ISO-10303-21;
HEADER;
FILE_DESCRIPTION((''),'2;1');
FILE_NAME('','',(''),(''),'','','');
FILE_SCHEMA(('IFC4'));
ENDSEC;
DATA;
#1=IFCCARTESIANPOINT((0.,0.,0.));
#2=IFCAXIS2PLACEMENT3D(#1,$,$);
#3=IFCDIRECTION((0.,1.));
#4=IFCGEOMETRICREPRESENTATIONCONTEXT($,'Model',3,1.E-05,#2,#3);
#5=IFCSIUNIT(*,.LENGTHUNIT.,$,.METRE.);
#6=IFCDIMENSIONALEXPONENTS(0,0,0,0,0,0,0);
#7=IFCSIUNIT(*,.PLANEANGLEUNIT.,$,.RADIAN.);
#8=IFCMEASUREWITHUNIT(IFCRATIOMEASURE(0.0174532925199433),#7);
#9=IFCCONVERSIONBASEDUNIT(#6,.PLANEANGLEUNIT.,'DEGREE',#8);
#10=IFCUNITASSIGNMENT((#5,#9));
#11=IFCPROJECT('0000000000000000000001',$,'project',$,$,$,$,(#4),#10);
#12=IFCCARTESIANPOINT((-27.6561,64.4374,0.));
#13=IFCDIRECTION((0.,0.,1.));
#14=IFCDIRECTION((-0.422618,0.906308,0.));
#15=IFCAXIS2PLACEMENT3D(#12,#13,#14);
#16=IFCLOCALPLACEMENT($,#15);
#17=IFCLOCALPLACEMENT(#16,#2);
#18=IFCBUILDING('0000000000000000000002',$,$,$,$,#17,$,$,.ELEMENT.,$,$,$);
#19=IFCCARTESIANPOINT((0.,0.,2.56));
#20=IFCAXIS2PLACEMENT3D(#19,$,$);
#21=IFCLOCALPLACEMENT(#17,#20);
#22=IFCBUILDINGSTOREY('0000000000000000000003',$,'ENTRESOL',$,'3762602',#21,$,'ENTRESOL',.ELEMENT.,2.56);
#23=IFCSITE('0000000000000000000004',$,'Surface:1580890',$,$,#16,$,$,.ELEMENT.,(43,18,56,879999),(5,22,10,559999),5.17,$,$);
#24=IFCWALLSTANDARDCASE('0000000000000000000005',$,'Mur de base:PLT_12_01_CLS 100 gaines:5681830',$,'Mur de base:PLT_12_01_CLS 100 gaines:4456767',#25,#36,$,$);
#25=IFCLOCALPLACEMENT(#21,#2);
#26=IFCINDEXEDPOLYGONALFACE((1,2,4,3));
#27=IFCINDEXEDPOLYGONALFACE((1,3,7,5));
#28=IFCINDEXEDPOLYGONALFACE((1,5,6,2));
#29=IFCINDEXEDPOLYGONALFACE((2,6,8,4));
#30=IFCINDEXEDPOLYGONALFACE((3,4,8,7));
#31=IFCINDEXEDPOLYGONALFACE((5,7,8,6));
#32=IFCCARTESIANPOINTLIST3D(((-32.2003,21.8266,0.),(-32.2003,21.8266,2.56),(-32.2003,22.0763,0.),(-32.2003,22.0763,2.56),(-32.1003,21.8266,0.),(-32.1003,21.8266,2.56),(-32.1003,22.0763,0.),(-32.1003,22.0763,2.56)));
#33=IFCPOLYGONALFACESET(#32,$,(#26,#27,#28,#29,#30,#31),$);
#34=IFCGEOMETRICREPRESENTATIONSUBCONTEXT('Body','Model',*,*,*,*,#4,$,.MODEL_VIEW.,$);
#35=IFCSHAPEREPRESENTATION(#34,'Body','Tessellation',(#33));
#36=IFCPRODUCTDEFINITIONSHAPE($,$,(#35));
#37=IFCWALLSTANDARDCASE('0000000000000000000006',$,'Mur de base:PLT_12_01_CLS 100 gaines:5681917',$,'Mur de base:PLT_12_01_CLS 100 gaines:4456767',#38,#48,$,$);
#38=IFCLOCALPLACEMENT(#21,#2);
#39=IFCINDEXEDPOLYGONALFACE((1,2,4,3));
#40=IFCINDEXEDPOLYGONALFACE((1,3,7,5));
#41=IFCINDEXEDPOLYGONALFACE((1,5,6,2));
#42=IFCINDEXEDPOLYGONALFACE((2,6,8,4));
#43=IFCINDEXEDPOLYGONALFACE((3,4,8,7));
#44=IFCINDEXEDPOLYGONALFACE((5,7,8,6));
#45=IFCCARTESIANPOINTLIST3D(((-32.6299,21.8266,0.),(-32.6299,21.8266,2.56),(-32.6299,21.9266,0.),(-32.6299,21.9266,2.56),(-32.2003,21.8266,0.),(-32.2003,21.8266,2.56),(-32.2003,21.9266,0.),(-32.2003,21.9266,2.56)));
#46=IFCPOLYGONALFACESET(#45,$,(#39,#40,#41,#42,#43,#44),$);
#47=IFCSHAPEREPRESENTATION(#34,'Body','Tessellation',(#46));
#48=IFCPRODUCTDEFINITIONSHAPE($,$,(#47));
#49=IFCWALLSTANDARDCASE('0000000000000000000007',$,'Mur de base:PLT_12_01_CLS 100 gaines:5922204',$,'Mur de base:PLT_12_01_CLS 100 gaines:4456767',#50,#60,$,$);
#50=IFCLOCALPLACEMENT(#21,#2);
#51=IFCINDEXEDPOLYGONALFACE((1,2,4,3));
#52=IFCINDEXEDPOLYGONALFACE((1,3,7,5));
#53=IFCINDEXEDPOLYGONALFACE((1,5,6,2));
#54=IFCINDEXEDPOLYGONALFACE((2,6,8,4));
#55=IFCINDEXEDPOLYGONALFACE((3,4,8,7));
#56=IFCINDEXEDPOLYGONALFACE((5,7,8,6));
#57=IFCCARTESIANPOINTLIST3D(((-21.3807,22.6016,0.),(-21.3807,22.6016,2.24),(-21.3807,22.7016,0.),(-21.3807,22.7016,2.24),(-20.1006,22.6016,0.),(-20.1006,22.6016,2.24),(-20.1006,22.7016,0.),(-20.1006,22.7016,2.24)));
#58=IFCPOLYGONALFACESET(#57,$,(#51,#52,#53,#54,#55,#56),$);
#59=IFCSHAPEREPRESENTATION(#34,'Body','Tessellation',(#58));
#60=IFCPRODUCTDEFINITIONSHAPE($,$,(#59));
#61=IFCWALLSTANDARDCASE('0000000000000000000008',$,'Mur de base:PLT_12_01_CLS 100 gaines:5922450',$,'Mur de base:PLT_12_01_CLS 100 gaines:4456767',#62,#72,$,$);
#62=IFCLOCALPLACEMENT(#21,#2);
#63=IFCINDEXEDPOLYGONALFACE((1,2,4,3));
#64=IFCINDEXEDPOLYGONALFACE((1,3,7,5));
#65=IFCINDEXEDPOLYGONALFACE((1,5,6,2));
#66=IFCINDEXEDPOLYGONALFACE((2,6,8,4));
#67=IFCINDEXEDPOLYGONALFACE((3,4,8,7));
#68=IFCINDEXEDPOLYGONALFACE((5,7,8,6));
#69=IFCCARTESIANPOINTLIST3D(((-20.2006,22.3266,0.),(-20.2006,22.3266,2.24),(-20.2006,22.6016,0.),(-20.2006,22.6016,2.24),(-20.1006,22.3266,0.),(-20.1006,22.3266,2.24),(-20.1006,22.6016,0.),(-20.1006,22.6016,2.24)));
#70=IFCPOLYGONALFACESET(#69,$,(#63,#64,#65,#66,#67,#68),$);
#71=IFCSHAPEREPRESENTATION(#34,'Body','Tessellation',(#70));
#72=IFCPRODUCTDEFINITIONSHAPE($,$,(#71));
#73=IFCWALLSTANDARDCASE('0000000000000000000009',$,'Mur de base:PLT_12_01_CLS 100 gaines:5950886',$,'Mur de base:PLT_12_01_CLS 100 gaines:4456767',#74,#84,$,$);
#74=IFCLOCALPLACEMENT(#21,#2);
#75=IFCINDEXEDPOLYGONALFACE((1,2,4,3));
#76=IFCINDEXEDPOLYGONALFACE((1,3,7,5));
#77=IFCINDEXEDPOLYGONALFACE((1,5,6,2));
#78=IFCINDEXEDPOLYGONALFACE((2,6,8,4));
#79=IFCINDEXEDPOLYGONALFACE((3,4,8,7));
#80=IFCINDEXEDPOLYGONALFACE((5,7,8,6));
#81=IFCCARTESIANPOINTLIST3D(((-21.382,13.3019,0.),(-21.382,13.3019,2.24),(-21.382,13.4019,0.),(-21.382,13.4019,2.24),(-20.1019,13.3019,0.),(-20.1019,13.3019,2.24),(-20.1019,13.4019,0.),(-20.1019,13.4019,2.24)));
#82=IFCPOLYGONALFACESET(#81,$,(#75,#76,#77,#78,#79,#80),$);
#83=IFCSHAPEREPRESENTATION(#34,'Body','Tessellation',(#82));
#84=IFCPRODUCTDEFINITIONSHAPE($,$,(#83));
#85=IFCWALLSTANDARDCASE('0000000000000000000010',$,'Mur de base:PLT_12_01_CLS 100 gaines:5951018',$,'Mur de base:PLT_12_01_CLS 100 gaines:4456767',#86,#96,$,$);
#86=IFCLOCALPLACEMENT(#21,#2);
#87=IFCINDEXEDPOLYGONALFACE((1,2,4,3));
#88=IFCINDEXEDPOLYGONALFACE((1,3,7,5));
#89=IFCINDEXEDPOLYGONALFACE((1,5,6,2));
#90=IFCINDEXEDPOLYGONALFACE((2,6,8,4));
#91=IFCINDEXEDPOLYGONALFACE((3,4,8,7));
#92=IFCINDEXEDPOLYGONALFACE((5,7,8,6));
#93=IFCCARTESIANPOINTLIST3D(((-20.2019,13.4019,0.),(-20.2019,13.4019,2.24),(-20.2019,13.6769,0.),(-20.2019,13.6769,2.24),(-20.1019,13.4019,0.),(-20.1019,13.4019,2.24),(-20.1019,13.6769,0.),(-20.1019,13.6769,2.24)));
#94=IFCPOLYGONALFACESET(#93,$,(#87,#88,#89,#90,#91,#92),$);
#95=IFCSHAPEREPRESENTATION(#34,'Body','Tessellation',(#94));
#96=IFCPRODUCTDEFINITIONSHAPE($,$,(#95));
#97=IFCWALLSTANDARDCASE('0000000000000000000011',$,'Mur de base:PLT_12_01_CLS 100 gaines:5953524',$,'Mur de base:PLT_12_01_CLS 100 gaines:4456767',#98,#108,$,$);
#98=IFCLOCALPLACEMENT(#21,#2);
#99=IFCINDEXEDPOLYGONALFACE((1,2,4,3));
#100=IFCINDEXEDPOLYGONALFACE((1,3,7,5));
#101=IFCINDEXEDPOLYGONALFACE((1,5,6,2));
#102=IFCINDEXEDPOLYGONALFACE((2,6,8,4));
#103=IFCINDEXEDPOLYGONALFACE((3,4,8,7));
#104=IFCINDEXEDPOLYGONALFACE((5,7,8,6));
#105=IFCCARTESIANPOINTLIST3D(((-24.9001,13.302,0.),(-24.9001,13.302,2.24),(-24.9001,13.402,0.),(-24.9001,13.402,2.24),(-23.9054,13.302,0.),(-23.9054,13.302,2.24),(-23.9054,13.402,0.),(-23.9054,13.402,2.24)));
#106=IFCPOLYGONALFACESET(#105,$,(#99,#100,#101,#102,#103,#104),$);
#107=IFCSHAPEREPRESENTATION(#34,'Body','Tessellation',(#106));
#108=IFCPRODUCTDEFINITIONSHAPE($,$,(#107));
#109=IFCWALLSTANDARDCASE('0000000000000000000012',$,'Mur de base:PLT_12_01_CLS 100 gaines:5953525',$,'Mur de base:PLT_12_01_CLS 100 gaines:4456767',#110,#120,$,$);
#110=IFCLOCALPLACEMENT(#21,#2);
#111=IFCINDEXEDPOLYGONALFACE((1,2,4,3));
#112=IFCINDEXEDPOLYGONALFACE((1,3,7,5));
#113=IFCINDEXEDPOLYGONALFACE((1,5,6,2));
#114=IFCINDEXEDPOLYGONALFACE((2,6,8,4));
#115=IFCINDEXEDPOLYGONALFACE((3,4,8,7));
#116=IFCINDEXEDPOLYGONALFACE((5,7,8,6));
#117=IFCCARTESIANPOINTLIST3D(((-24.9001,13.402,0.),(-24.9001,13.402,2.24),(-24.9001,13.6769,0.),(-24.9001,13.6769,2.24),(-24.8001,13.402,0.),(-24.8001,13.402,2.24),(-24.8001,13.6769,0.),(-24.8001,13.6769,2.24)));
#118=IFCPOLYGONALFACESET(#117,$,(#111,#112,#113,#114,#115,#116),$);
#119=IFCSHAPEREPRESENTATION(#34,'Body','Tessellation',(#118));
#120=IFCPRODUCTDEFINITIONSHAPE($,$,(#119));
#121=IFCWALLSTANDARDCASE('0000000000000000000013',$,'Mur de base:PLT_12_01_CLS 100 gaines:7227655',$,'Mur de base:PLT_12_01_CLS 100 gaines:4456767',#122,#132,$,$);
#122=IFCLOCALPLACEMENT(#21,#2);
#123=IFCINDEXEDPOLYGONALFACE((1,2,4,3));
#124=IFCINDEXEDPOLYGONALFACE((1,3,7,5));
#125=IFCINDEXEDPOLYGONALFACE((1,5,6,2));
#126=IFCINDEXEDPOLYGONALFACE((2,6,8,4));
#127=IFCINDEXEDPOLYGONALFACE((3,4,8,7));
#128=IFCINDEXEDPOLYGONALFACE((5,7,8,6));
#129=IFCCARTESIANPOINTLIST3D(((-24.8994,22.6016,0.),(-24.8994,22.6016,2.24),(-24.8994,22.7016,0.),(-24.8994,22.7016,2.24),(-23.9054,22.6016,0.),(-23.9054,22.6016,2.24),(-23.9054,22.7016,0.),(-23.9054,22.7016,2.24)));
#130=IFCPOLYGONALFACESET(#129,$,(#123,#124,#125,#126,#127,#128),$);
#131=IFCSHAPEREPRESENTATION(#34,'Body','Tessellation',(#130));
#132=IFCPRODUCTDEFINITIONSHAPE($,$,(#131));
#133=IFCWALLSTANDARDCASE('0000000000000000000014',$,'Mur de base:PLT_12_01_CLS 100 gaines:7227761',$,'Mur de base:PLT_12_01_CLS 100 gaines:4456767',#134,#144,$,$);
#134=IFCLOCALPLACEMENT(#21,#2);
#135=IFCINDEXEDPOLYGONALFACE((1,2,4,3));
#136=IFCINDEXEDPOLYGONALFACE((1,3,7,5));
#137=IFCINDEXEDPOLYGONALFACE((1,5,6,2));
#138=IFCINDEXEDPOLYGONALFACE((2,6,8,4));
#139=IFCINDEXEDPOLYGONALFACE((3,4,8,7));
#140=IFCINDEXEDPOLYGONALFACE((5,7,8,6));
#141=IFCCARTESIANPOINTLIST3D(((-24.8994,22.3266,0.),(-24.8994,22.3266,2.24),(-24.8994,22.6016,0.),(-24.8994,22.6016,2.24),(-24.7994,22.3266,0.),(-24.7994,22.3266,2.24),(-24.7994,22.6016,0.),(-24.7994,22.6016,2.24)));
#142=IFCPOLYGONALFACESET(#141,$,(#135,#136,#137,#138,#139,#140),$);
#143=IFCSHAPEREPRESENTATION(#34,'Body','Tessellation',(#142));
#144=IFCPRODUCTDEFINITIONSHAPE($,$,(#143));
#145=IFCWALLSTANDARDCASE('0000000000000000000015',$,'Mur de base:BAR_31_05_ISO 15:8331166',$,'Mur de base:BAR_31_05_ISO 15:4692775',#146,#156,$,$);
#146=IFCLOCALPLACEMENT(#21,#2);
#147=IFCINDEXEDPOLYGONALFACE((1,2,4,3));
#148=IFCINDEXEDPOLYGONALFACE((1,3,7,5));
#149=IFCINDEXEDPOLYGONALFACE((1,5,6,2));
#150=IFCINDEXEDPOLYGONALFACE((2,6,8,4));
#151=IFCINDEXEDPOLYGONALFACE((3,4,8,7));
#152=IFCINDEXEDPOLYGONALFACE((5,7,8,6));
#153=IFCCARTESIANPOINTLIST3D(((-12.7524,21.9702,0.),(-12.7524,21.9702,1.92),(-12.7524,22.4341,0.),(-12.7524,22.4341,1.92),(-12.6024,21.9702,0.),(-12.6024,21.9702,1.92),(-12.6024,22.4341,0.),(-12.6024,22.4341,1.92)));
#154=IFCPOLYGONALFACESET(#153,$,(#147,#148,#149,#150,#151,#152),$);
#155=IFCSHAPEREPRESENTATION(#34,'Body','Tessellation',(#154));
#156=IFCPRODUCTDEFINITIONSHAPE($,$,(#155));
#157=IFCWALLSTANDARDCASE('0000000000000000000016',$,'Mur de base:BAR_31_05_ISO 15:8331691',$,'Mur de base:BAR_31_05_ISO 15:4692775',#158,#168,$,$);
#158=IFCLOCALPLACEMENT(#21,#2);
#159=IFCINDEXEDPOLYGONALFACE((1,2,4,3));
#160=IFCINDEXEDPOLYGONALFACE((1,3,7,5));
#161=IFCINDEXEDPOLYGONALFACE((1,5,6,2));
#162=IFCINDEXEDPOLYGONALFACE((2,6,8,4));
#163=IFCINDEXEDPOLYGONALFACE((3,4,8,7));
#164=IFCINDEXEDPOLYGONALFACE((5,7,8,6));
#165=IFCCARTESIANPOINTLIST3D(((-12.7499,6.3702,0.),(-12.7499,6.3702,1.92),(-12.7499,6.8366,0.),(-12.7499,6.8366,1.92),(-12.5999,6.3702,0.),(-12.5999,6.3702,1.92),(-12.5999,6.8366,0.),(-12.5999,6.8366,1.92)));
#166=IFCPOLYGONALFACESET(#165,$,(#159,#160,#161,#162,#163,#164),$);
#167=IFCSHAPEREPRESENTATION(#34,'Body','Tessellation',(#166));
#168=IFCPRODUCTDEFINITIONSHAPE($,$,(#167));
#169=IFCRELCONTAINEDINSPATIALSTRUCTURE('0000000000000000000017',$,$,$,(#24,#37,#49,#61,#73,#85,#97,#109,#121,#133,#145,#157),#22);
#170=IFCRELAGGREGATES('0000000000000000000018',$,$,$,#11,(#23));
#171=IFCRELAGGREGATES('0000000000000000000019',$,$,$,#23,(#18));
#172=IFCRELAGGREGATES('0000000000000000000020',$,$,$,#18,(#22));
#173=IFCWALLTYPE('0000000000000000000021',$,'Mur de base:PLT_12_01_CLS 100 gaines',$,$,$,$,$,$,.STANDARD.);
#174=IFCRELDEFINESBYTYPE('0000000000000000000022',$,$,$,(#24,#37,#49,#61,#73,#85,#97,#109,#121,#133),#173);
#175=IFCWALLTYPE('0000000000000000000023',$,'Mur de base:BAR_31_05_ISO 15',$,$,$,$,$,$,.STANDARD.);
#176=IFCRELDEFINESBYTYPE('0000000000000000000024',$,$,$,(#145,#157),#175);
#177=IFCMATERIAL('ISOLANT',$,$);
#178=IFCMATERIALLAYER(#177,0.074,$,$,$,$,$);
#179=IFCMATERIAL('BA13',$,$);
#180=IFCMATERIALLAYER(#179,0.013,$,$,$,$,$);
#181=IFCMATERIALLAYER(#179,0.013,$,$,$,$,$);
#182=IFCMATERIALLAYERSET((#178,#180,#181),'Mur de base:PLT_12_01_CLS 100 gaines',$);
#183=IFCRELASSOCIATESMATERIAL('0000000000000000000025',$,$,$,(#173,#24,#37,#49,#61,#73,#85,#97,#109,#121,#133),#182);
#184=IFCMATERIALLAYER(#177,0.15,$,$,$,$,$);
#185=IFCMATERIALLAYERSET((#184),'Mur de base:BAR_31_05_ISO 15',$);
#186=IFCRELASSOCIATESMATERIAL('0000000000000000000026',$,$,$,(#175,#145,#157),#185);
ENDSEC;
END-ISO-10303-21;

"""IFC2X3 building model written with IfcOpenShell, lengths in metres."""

from ifc_helpers import new_model, entity, si_unit, converted_unit, direction, frame, frame_2d, origin, place, context, subcontext, project, spatial, rectangle, extrude, clip, halfspace, material, layer, layer_set, layer_usage, type_object, element, save


model = new_model("IFC2X3")

# Units and contexts
model_context = context("Model", 3, precision=1e-05, world=origin(), true_north=direction((0.0, 1.0)))
body_context = subcontext(model_context, "Body", "Model", "MODEL_VIEW")
ifc_project = project(units=[si_unit("LENGTHUNIT", "METRE"), converted_unit("PLANEANGLEUNIT", "DEGREE", entity("IfcRatioMeasure", 0.0174532925199433), si_unit("PLANEANGLEUNIT", "RADIAN"), dimensions=[0, 0, 0, 0, 0, 0, 0])], contexts=[model_context])

# Site, building, storey
site_placement = place(None, frame((-27.6561, 64.4374, 0.0), z_axis=(0.0, 0.0, 1.0), x_axis=(-0.422618, 0.906308, 0.0)))
site = spatial("IfcSite", under=ifc_project, at=site_placement, Name="Surface:1580890", CompositionType="ELEMENT", RefLatitude=(43, 18, 56, 879999), RefLongitude=(5, 22, 10, 559999), RefElevation=5.17)
building_placement = place(site_placement, origin())
building = spatial("IfcBuilding", under=site, at=building_placement, CompositionType="ELEMENT")
storey_placement = place(building_placement, frame((0.0, 0.0, 2.56)))
storey = spatial("IfcBuildingStorey", under=building, at=storey_placement, Name="ENTRESOL", ObjectType="3762602", LongName="ENTRESOL", CompositionType="ELEMENT", Elevation=2.56)

# Shared definitions
ifc_material_1 = material(Name="BA13")
ifc_material_2 = material(Name="ISOLANT")

# Walls
ifc_layer_1 = layer(ifc_material_2, 0.074)
ifc_layer_2 = layer(ifc_material_1, 0.013)
ifc_layer_3 = layer(ifc_material_1, 0.013)
ifc_layer_set_1 = layer_set([ifc_layer_1, ifc_layer_2, ifc_layer_3], Name="Mur de base:PLT_12_01_CLS 100 gaines")
wall_type_1 = type_object("IfcWallType", Name="Mur de base:PLT_12_01_CLS 100 gaines", PredefinedType="STANDARD", material=ifc_layer_set_1)
ifc_layer_usage_1 = layer_usage(ifc_layer_set_1, "AXIS2", "POSITIVE", -0.05)
wall_1_placement = place(storey_placement, frame((-32.1503, 22.0763, 0.0), z_axis=(0.0, 0.0, 1.0), x_axis=(0.0, -1.0, 0.0)))
element("IfcWallStandardCase", 1, at=wall_1_placement, inside=storey, type_object=wall_type_1, material=ifc_layer_usage_1, Name="Mur de base:PLT_12_01_CLS 100 gaines:5681830", ObjectType="Mur de base:PLT_12_01_CLS 100 gaines:4456767", context=body_context, shape_type="Clipping", body=[
    clip(extrude(rectangle(XDim=0.2497, YDim=0.1, at=frame_2d((0.1249, 0.0), x_axis=(-1.0, 0.0))), origin(), (0.0, 0.0, 1.0), 2.56), halfspace(frame((0.0, 0.0, -2.56)), True)),
])
ifc_layer_usage_2 = layer_usage(ifc_layer_set_1, "AXIS2", "POSITIVE", -0.05)
wall_2_placement = place(storey_placement, frame((-32.2003, 21.8766, 0.0), z_axis=(0.0, 0.0, 1.0), x_axis=(-1.0, 0.0, 0.0)))
element("IfcWallStandardCase", 2, at=wall_2_placement, inside=storey, type_object=wall_type_1, material=ifc_layer_usage_2, Name="Mur de base:PLT_12_01_CLS 100 gaines:5681917", ObjectType="Mur de base:PLT_12_01_CLS 100 gaines:4456767", context=body_context, shape_type="Clipping", body=[
    clip(extrude(rectangle(XDim=0.4295, YDim=0.1, at=frame_2d((0.2148, 0.0), x_axis=(-1.0, 0.0))), origin(), (0.0, 0.0, 1.0), 2.56), halfspace(frame((0.0, 0.0, -2.56)), True)),
])
ifc_layer_usage_3 = layer_usage(ifc_layer_set_1, "AXIS2", "NEGATIVE", 0.05)
wall_3_placement = place(storey_placement, frame((-20.1006, 22.6516, 0.0), z_axis=(0.0, 0.0, 1.0), x_axis=(-1.0, 0.0, 0.0)))
element("IfcWallStandardCase", 3, at=wall_3_placement, inside=storey, type_object=wall_type_1, material=ifc_layer_usage_3, Name="Mur de base:PLT_12_01_CLS 100 gaines:5922204", ObjectType="Mur de base:PLT_12_01_CLS 100 gaines:4456767", context=body_context, shape_type="Clipping", body=[
    clip(extrude(rectangle(XDim=1.2801, YDim=0.1, at=frame_2d((0.64, 0.0), x_axis=(-1.0, 0.0))), origin(), (0.0, 0.0, 1.0), 2.24), halfspace(frame((0.0, 0.0, -2.56)), True)),
])
ifc_layer_usage_4 = layer_usage(ifc_layer_set_1, "AXIS2", "NEGATIVE", 0.05)
wall_4_placement = place(storey_placement, frame((-20.1506, 22.3266, 0.0), z_axis=(0.0, 0.0, 1.0), x_axis=(0.0, 1.0, 0.0)))
element("IfcWallStandardCase", 4, at=wall_4_placement, inside=storey, type_object=wall_type_1, material=ifc_layer_usage_4, Name="Mur de base:PLT_12_01_CLS 100 gaines:5922450", ObjectType="Mur de base:PLT_12_01_CLS 100 gaines:4456767", context=body_context, shape_type="Clipping", body=[
    clip(extrude(rectangle(XDim=0.275, YDim=0.1, at=frame_2d((0.1375, 0.0), x_axis=(-1.0, 0.0))), origin(), (0.0, 0.0, 1.0), 2.24), halfspace(frame((0.0, 0.0, -2.56)), True)),
])
ifc_layer_usage_5 = layer_usage(ifc_layer_set_1, "AXIS2", "POSITIVE", -0.05)
wall_5_placement = place(storey_placement, frame((-20.1019, 13.3519, 0.0), z_axis=(0.0, 0.0, 1.0), x_axis=(-1.0, 0.0, 0.0)))
element("IfcWallStandardCase", 5, at=wall_5_placement, inside=storey, type_object=wall_type_1, material=ifc_layer_usage_5, Name="Mur de base:PLT_12_01_CLS 100 gaines:5950886", ObjectType="Mur de base:PLT_12_01_CLS 100 gaines:4456767", context=body_context, shape_type="Clipping", body=[
    clip(extrude(rectangle(XDim=1.2801, YDim=0.1, at=frame_2d((0.64, 0.0), x_axis=(-1.0, 0.0))), origin(), (0.0, 0.0, 1.0), 2.24), halfspace(frame((0.0, 0.0, -2.56)), True)),
])
ifc_layer_usage_6 = layer_usage(ifc_layer_set_1, "AXIS2", "POSITIVE", -0.05)
wall_6_placement = place(storey_placement, frame((-20.1519, 13.6769, 0.0), z_axis=(0.0, 0.0, 1.0), x_axis=(0.0, -1.0, 0.0)))
element("IfcWallStandardCase", 6, at=wall_6_placement, inside=storey, type_object=wall_type_1, material=ifc_layer_usage_6, Name="Mur de base:PLT_12_01_CLS 100 gaines:5951018", ObjectType="Mur de base:PLT_12_01_CLS 100 gaines:4456767", context=body_context, shape_type="Clipping", body=[
    clip(extrude(rectangle(XDim=0.275, YDim=0.1, at=frame_2d((0.1375, 0.0), x_axis=(-1.0, 0.0))), origin(), (0.0, 0.0, 1.0), 2.24), halfspace(frame((0.0, 0.0, -2.56)), True)),
])
ifc_layer_usage_7 = layer_usage(ifc_layer_set_1, "AXIS2", "NEGATIVE", 0.05)
wall_7_placement = place(storey_placement, frame((-24.9001, 13.352, 0.0)))
element("IfcWallStandardCase", 7, at=wall_7_placement, inside=storey, type_object=wall_type_1, material=ifc_layer_usage_7, Name="Mur de base:PLT_12_01_CLS 100 gaines:5953524", ObjectType="Mur de base:PLT_12_01_CLS 100 gaines:4456767", context=body_context, shape_type="Clipping", body=[
    clip(extrude(rectangle(XDim=0.9947, YDim=0.1, at=frame_2d((0.4973, 0.0), x_axis=(-1.0, 0.0))), origin(), (0.0, 0.0, 1.0), 2.24), halfspace(frame((0.0, 0.0, -2.56)), True)),
])
ifc_layer_usage_8 = layer_usage(ifc_layer_set_1, "AXIS2", "NEGATIVE", 0.05)
wall_8_placement = place(storey_placement, frame((-24.8501, 13.6769, 0.0), z_axis=(0.0, 0.0, 1.0), x_axis=(0.0, -1.0, 0.0)))
element("IfcWallStandardCase", 8, at=wall_8_placement, inside=storey, type_object=wall_type_1, material=ifc_layer_usage_8, Name="Mur de base:PLT_12_01_CLS 100 gaines:5953525", ObjectType="Mur de base:PLT_12_01_CLS 100 gaines:4456767", context=body_context, shape_type="Clipping", body=[
    clip(extrude(rectangle(XDim=0.2749, YDim=0.1, at=frame_2d((0.1374, 0.0), x_axis=(-1.0, 0.0))), origin(), (0.0, 0.0, 1.0), 2.24), halfspace(frame((0.0, 0.0, -2.56)), True)),
])
ifc_layer_usage_9 = layer_usage(ifc_layer_set_1, "AXIS2", "POSITIVE", -0.05)
wall_9_placement = place(storey_placement, frame((-24.8994, 22.6516, 0.0)))
element("IfcWallStandardCase", 9, at=wall_9_placement, inside=storey, type_object=wall_type_1, material=ifc_layer_usage_9, Name="Mur de base:PLT_12_01_CLS 100 gaines:7227655", ObjectType="Mur de base:PLT_12_01_CLS 100 gaines:4456767", context=body_context, shape_type="Clipping", body=[
    clip(extrude(rectangle(XDim=0.994, YDim=0.1, at=frame_2d((0.497, 0.0), x_axis=(-1.0, 0.0))), origin(), (0.0, 0.0, 1.0), 2.24), halfspace(frame((0.0, 0.0, -2.56)), True)),
])
ifc_layer_usage_10 = layer_usage(ifc_layer_set_1, "AXIS2", "POSITIVE", -0.05)
wall_10_placement = place(storey_placement, frame((-24.8494, 22.3266, 0.0), z_axis=(0.0, 0.0, 1.0), x_axis=(0.0, 1.0, 0.0)))
element("IfcWallStandardCase", 10, at=wall_10_placement, inside=storey, type_object=wall_type_1, material=ifc_layer_usage_10, Name="Mur de base:PLT_12_01_CLS 100 gaines:7227761", ObjectType="Mur de base:PLT_12_01_CLS 100 gaines:4456767", context=body_context, shape_type="Clipping", body=[
    clip(extrude(rectangle(XDim=0.275, YDim=0.1, at=frame_2d((0.1375, 0.0), x_axis=(-1.0, 0.0))), origin(), (0.0, 0.0, 1.0), 2.24), halfspace(frame((0.0, 0.0, -2.56)), True)),
])
ifc_layer_4 = layer(ifc_material_2, 0.15)
ifc_layer_set_2 = layer_set([ifc_layer_4], Name="Mur de base:BAR_31_05_ISO 15")
ifc_layer_usage_11 = layer_usage(ifc_layer_set_2, "AXIS2", "NEGATIVE", 0.075)
wall_type_2 = type_object("IfcWallType", Name="Mur de base:BAR_31_05_ISO 15", PredefinedType="STANDARD", material=ifc_layer_set_2)
wall_11_placement = place(storey_placement, frame((-12.6774, 22.4341, 0.0), z_axis=(0.0, 0.0, 1.0), x_axis=(0.0, -1.0, 0.0)))
element("IfcWallStandardCase", 11, at=wall_11_placement, inside=storey, type_object=wall_type_2, material=ifc_layer_usage_11, Name="Mur de base:BAR_31_05_ISO 15:8331166", ObjectType="Mur de base:BAR_31_05_ISO 15:4692775", context=body_context, shape_type="Clipping", body=[
    clip(extrude(rectangle(XDim=0.464, YDim=0.15, at=frame_2d((0.232, 0.0), x_axis=(-1.0, 0.0))), origin(), (0.0, 0.0, 1.0), 1.92), halfspace(frame((0.0, 0.0, -2.56)), True)),
])
ifc_layer_usage_12 = layer_usage(ifc_layer_set_2, "AXIS2", "NEGATIVE", 0.075)
wall_12_placement = place(storey_placement, frame((-12.6749, 6.8366, 0.0), z_axis=(0.0, 0.0, 1.0), x_axis=(0.0, -1.0, 0.0)))
element("IfcWallStandardCase", 12, at=wall_12_placement, inside=storey, type_object=wall_type_2, material=ifc_layer_usage_12, Name="Mur de base:BAR_31_05_ISO 15:8331691", ObjectType="Mur de base:BAR_31_05_ISO 15:4692775", context=body_context, shape_type="Clipping", body=[
    clip(extrude(rectangle(XDim=0.4665, YDim=0.15, at=frame_2d((0.2332, 0.0), x_axis=(-1.0, 0.0))), origin(), (0.0, 0.0, 1.0), 1.92), halfspace(frame((0.0, 0.0, -2.56)), True)),
])

save(model, "model.ifc")
